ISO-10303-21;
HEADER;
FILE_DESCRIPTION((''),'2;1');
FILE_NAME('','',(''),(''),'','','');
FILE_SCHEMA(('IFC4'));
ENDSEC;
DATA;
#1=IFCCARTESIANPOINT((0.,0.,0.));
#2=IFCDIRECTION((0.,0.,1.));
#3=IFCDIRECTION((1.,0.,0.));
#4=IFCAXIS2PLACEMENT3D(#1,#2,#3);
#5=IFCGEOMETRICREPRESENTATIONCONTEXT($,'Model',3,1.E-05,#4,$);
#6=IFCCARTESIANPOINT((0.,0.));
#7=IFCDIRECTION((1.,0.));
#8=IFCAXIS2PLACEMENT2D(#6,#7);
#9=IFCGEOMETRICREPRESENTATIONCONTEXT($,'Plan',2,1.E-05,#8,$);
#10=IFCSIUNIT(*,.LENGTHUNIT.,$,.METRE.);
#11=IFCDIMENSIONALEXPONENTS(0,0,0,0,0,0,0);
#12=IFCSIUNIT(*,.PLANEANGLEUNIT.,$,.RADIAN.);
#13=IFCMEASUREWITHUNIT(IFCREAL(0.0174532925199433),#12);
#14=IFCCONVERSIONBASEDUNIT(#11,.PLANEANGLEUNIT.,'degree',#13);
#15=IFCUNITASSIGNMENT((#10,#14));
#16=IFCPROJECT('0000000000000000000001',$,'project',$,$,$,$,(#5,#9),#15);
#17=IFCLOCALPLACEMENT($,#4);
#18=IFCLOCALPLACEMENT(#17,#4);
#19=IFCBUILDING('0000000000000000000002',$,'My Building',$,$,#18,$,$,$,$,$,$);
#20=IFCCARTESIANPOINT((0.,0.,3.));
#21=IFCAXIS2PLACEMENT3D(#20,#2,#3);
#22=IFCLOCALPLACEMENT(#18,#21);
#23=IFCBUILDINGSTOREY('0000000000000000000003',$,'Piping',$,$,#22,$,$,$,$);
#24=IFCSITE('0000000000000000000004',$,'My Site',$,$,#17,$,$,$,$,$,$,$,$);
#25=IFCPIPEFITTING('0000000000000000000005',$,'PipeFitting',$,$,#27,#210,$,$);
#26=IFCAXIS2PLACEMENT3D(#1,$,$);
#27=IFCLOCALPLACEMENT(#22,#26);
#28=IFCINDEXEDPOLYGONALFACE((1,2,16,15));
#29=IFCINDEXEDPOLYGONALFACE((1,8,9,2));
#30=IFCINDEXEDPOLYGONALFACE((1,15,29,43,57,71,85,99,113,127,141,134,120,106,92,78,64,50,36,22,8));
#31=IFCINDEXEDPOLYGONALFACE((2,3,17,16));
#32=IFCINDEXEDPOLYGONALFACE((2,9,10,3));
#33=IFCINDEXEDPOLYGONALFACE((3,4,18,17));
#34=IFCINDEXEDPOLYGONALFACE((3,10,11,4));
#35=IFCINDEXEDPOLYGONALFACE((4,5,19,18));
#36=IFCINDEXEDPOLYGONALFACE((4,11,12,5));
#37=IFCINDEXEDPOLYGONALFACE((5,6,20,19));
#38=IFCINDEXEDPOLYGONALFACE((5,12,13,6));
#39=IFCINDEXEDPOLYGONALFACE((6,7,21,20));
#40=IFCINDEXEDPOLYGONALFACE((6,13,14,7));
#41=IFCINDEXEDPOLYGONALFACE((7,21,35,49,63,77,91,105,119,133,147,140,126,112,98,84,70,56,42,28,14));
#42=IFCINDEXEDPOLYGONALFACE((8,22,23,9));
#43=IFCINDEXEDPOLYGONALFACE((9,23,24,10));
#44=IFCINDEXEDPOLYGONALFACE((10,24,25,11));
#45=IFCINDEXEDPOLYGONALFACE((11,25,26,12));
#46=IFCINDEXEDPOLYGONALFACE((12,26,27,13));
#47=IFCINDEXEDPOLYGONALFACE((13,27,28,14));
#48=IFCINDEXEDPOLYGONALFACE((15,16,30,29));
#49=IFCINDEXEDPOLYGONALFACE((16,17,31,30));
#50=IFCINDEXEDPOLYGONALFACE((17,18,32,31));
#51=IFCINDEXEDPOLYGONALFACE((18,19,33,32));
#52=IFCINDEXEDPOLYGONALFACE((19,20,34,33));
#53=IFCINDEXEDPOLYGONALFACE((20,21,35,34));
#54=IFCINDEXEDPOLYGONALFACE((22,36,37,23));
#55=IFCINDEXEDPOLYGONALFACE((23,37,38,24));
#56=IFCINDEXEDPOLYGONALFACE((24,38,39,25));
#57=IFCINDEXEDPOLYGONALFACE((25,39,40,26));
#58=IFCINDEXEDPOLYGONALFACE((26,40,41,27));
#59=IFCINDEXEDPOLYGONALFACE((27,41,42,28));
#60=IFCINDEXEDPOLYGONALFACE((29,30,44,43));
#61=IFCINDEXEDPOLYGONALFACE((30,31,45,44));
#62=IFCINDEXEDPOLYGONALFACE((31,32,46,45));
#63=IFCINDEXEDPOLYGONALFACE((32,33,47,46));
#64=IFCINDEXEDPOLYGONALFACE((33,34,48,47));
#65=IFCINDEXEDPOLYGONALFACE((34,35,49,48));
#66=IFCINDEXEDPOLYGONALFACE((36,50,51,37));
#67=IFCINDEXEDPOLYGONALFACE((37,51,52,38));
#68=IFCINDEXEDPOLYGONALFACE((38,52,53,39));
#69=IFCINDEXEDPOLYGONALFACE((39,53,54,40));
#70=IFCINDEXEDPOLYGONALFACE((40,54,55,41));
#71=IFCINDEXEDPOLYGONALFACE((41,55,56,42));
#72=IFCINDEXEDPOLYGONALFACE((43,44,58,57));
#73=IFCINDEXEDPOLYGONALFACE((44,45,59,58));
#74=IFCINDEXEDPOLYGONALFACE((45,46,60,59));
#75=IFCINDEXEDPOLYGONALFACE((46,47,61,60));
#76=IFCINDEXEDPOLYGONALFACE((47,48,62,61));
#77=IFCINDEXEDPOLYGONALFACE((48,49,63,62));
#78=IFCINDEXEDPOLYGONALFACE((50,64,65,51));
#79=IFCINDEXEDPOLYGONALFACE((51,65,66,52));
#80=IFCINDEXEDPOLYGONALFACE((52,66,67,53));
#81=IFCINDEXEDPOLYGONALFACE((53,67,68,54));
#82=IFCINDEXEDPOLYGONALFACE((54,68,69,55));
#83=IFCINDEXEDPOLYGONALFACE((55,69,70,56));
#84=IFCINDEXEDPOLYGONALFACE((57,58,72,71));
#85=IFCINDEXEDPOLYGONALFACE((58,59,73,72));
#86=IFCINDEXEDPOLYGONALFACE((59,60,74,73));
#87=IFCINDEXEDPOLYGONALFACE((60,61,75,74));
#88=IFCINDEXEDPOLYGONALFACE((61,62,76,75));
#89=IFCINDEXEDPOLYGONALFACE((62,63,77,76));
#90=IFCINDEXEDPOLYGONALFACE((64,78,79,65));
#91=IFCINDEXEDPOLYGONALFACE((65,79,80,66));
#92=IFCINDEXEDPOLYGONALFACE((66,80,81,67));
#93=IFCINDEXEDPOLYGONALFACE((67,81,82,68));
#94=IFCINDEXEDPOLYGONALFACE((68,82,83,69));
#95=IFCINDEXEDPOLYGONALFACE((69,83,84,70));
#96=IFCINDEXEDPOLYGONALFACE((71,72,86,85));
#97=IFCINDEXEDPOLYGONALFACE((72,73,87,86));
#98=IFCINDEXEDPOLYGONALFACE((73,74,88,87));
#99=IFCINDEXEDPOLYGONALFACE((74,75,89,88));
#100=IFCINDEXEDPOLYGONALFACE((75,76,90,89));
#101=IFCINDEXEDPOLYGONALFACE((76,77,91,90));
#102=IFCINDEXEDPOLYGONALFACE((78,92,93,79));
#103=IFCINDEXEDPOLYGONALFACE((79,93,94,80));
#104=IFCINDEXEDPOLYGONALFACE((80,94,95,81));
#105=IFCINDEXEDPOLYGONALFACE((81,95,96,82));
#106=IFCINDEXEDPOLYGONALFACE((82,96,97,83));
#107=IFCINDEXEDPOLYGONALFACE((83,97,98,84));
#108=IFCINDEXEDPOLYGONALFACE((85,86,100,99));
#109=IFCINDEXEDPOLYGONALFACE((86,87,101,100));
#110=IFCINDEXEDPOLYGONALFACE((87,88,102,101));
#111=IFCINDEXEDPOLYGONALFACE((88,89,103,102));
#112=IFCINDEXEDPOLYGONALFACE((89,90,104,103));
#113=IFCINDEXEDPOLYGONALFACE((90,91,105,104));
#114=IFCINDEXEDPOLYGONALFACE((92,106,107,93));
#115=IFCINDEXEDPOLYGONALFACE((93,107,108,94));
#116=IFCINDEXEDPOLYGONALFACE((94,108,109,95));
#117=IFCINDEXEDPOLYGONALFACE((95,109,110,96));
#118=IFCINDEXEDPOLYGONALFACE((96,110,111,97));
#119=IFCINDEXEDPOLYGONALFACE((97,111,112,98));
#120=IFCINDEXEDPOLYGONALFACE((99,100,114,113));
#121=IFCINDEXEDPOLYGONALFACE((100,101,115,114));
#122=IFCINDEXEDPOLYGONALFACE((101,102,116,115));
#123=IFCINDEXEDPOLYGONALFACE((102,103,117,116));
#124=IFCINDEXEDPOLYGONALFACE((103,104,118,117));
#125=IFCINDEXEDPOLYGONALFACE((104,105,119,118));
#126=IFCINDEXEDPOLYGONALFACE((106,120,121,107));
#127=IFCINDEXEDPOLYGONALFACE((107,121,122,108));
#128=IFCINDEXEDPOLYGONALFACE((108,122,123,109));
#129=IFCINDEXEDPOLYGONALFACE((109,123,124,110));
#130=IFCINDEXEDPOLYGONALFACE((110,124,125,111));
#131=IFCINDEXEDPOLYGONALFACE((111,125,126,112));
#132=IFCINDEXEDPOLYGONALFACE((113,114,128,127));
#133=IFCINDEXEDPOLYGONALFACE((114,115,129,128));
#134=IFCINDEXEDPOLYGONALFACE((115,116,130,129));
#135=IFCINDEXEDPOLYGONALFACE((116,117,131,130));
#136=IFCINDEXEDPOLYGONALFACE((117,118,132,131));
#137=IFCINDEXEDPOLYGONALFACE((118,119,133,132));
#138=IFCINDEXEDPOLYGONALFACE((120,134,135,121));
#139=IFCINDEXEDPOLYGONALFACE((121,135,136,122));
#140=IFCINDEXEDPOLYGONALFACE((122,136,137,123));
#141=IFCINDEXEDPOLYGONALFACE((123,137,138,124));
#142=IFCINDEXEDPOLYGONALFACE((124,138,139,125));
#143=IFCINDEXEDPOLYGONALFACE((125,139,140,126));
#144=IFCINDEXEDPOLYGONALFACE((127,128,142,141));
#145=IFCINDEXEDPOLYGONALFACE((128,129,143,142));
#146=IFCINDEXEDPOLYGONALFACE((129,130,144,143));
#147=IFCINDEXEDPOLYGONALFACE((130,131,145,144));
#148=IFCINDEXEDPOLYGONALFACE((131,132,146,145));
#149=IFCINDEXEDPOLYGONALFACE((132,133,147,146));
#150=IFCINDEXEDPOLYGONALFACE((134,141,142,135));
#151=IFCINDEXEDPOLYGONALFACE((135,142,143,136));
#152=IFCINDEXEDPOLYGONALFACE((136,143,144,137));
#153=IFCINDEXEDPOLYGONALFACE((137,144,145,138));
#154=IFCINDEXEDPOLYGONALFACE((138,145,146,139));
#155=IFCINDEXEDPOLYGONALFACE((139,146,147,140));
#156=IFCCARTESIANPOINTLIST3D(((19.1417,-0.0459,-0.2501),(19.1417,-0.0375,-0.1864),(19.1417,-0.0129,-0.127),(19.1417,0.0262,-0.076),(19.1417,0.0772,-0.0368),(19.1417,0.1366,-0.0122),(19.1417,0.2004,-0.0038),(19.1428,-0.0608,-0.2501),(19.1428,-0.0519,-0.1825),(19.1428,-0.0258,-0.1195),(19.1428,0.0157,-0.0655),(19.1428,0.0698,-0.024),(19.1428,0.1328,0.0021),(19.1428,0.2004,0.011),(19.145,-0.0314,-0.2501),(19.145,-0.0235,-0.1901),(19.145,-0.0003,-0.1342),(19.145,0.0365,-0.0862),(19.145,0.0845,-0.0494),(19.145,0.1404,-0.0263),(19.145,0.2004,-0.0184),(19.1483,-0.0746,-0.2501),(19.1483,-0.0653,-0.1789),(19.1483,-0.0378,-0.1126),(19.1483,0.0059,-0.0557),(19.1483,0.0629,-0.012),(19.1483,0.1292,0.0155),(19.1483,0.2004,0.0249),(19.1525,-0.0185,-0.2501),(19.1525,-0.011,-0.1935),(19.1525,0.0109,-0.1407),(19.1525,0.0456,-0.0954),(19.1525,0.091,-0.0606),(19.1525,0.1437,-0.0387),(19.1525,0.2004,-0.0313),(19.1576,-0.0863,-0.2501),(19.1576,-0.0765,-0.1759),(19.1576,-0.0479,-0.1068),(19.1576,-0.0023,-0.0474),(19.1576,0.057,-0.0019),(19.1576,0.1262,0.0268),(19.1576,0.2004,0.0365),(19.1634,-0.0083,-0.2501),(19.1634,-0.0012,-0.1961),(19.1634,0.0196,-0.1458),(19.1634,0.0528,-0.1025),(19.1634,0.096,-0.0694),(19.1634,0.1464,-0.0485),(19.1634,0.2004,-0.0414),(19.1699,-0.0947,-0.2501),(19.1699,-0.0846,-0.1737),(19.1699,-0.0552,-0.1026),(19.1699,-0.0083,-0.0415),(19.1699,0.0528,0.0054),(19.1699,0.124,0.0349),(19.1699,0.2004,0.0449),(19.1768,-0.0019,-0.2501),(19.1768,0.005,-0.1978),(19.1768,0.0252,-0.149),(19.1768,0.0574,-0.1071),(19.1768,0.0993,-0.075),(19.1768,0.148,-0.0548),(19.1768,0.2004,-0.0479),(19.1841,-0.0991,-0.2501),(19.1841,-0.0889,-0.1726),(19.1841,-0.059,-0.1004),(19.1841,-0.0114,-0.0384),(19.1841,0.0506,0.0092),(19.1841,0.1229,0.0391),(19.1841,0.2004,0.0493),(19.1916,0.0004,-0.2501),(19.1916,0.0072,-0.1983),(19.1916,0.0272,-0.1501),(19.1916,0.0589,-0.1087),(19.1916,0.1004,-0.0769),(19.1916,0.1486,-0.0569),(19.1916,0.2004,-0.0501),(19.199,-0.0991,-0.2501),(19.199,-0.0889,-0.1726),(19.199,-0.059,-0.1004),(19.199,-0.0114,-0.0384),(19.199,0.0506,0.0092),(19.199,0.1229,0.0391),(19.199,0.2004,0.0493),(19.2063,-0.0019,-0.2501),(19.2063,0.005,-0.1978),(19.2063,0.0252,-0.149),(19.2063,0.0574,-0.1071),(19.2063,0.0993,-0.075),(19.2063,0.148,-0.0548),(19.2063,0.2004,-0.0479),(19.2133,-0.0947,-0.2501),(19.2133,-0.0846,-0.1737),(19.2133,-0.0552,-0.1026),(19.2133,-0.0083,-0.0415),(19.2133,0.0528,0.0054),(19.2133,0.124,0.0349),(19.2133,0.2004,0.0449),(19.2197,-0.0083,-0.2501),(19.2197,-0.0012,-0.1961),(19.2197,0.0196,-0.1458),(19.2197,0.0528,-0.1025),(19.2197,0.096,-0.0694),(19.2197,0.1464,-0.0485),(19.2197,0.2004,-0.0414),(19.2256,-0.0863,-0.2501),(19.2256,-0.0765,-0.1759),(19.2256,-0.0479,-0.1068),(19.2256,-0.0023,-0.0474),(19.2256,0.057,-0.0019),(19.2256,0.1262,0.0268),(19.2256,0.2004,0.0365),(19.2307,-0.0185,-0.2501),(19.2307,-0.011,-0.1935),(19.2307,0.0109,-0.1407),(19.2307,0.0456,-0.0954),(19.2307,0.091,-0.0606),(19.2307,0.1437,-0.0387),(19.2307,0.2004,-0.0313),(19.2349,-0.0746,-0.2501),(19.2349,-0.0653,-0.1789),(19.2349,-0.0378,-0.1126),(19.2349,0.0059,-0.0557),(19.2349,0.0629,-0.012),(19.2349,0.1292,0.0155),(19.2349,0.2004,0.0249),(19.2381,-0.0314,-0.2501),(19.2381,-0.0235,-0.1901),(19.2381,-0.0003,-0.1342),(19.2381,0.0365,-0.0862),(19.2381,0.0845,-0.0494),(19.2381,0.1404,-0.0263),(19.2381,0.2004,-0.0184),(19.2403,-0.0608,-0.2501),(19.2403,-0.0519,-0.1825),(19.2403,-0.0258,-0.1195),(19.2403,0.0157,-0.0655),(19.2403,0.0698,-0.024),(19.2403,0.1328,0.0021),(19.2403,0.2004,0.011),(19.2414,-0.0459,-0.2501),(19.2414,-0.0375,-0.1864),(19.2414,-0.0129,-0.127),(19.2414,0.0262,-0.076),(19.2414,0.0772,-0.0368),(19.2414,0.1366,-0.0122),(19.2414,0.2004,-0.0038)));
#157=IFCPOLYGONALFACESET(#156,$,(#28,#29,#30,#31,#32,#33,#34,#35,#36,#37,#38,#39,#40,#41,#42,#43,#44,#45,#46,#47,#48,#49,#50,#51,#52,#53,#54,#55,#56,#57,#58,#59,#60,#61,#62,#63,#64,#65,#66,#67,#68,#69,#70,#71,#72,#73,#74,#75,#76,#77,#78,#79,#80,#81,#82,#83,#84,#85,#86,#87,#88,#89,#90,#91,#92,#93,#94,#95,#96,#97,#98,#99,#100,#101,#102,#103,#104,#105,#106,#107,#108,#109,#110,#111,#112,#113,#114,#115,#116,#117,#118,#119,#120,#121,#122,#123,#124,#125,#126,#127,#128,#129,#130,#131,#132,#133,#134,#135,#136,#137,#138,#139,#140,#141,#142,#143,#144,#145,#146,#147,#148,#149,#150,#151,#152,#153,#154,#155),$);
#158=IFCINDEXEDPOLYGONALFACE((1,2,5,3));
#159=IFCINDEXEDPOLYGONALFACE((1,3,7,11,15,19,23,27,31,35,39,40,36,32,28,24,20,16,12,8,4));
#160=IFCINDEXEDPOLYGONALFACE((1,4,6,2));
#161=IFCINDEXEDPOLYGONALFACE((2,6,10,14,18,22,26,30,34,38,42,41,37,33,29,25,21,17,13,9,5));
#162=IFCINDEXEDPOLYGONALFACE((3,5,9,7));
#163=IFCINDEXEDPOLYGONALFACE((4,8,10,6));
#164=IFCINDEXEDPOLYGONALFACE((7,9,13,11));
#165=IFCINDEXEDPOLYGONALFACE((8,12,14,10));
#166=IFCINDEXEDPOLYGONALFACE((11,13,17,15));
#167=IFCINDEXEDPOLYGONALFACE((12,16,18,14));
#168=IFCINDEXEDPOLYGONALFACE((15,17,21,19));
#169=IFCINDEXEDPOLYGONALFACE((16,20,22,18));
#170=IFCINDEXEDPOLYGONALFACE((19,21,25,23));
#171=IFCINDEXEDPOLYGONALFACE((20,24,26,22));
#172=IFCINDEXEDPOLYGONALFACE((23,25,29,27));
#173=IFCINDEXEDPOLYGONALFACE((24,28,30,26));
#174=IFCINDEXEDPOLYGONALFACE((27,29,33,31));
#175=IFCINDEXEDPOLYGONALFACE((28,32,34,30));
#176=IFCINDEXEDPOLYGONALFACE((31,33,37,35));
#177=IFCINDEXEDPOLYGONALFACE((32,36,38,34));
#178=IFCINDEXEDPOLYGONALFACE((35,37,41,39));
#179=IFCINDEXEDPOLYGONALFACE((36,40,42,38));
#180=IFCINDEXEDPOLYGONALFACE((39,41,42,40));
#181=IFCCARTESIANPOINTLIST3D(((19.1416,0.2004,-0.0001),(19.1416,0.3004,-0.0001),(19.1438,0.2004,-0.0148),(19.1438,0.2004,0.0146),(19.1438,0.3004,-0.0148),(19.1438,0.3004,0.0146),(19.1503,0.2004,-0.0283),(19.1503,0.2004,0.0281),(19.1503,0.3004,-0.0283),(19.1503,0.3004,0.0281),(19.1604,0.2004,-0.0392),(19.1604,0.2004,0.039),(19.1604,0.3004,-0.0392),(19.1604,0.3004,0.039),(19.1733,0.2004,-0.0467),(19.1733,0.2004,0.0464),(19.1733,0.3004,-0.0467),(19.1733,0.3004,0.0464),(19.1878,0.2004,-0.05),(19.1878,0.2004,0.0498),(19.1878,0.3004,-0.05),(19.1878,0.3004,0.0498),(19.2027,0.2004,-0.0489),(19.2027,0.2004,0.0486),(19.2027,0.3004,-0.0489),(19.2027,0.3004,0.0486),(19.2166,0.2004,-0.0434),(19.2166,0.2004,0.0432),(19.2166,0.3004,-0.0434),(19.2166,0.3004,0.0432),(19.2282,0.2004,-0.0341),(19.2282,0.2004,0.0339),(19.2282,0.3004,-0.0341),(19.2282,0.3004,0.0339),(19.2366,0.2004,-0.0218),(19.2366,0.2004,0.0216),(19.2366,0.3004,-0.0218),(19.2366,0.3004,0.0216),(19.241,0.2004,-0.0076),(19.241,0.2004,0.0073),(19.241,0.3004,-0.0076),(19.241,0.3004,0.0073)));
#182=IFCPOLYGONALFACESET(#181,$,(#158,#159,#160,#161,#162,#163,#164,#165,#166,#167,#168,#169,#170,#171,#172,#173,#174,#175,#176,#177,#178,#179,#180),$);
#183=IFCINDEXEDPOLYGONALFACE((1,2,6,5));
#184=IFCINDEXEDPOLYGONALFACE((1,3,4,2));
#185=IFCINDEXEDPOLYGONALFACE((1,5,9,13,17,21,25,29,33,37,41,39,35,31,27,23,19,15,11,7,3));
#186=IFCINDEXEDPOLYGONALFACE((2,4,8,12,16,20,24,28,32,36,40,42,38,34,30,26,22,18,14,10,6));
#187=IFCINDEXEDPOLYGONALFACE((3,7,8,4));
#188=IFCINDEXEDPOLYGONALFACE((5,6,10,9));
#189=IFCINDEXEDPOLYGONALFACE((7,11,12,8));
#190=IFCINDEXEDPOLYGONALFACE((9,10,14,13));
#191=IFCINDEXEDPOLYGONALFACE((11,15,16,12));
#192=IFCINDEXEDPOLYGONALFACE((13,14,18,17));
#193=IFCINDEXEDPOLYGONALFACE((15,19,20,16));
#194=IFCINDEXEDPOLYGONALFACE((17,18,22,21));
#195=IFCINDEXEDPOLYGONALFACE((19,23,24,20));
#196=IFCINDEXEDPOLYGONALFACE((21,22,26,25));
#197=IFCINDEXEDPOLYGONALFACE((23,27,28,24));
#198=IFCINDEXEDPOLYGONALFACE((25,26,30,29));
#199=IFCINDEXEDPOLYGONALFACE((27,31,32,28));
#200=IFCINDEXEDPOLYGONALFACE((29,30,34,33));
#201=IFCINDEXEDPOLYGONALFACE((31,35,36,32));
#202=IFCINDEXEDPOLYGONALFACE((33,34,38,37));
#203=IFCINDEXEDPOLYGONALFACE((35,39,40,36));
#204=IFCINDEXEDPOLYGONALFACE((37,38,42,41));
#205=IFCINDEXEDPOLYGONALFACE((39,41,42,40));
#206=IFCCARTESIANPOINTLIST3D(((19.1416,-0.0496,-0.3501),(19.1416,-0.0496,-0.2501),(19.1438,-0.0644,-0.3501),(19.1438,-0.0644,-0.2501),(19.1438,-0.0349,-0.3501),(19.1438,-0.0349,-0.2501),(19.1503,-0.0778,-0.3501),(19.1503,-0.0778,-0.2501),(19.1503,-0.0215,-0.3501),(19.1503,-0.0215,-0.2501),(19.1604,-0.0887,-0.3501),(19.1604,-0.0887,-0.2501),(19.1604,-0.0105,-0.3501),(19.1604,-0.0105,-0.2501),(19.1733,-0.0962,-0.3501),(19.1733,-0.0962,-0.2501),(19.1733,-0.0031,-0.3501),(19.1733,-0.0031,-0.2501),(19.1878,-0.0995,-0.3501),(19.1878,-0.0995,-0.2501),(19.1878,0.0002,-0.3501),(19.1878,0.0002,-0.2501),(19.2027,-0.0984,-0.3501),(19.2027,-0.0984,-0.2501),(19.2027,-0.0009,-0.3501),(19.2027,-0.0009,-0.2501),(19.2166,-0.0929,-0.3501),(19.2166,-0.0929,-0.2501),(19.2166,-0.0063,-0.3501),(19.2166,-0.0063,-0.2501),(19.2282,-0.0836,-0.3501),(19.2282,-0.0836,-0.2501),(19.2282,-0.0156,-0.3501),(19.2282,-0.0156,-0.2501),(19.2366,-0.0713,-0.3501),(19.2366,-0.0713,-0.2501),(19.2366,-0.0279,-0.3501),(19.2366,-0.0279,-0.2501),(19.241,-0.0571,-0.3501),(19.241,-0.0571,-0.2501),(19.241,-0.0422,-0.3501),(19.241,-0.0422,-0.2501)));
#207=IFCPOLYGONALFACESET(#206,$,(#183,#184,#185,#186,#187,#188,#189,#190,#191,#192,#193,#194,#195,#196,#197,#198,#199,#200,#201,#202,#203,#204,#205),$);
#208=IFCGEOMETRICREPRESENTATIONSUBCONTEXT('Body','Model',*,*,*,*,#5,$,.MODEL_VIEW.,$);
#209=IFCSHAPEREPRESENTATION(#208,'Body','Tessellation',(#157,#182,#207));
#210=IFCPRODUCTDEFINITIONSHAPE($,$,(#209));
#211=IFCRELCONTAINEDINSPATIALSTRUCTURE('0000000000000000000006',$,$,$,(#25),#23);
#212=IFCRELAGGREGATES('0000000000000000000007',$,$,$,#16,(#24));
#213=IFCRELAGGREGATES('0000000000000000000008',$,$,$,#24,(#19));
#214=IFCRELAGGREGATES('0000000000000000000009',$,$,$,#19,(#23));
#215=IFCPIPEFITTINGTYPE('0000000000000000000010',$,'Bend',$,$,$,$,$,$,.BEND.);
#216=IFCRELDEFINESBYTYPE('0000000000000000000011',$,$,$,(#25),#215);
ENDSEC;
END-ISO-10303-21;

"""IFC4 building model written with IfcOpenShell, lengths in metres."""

from ifc_helpers import new_model, entity, si_unit, converted_unit, frame, origin_with_axes, origin_2d_with_axis, place, context, subcontext, project, spatial, circle, extrude, source, transform, mapped, type_object, type_shapes, element, save


model = new_model("IFC4")

# Units and contexts
model_context = context("Model", 3, precision=1e-05, world=origin_with_axes())
plan_context = context("Plan", 2, precision=1e-05, world=origin_2d_with_axis())
body_context = subcontext(model_context, "Body", "Model", "MODEL_VIEW")
ifc_project = project(units=[si_unit("LENGTHUNIT", "METRE"), converted_unit("PLANEANGLEUNIT", "degree", entity("IfcReal", 0.0174532925199433), si_unit("PLANEANGLEUNIT", "RADIAN"), dimensions=[0, 0, 0, 0, 0, 0, 0])], contexts=[model_context, plan_context])

# Site, building, storey
site_placement = place(None, origin_with_axes())
site = spatial("IfcSite", under=ifc_project, at=site_placement, Name="My Site")
building_placement = place(site_placement, origin_with_axes())
building = spatial("IfcBuilding", under=site, at=building_placement, Name="My Building")
storey_placement = place(building_placement, frame((0.0, 0.0, 3.0), z_axis=(0.0, 0.0, 1.0), x_axis=(1.0, 0.0, 0.0)))
storey = spatial("IfcBuildingStorey", under=building, at=storey_placement, Name="Piping")

# Pipe fitting
pipe_fitting_type = type_object("IfcPipeFittingType", Name="Bend", PredefinedType="BEND")
shared_shape = source(origin_with_axes(), body_context, "Body", "SolidModel", [
    entity("IfcSweptDiskSolid", entity("IfcIndexedPolyCurve", entity("IfcCartesianPointList3D", [[0.0, 0.0, -0.1], [0.0, -0.0732, -0.2768], [0.0, -0.25, -0.35]]), [entity("IfcArcIndex", [1, 2, 3])]), 0.05),
    extrude(circle(Radius=0.05), origin_with_axes(), (0.0, 0.0, -1.0), 0.1),
    extrude(circle(Radius=0.05), frame((0.0, -0.25, -0.35), z_axis=(0.0, -1.0, 0.0), x_axis=(1.0, 0.0, 0.0)), (0.0, 0.0, 1.0), 0.1),
])
type_shapes(pipe_fitting_type, [shared_shape])
for number, where, z_axis, x_axis, name in (
    (1, (19.1916, 0.3004, -0.0001), (0.0, 1.0, 0.0), (-1.0, 0.0, 0.0), "PipeFitting"),
):
    element("IfcPipeFitting", number, at=place(storey_placement, frame(where, z_axis=z_axis, x_axis=x_axis)), inside=storey, type_object=pipe_fitting_type, Name=name, context=body_context, shape_type="MappedRepresentation", body=[
        mapped(shared_shape, transform((0.0, 0.0, 0.0), x_axis=(1.0, 0.0, 0.0), y_axis=(0.0, 1.0, 0.0), z_axis=(0.0, 0.0, 1.0), scale=1.0)),
    ])

save(model, "model.ifc")
